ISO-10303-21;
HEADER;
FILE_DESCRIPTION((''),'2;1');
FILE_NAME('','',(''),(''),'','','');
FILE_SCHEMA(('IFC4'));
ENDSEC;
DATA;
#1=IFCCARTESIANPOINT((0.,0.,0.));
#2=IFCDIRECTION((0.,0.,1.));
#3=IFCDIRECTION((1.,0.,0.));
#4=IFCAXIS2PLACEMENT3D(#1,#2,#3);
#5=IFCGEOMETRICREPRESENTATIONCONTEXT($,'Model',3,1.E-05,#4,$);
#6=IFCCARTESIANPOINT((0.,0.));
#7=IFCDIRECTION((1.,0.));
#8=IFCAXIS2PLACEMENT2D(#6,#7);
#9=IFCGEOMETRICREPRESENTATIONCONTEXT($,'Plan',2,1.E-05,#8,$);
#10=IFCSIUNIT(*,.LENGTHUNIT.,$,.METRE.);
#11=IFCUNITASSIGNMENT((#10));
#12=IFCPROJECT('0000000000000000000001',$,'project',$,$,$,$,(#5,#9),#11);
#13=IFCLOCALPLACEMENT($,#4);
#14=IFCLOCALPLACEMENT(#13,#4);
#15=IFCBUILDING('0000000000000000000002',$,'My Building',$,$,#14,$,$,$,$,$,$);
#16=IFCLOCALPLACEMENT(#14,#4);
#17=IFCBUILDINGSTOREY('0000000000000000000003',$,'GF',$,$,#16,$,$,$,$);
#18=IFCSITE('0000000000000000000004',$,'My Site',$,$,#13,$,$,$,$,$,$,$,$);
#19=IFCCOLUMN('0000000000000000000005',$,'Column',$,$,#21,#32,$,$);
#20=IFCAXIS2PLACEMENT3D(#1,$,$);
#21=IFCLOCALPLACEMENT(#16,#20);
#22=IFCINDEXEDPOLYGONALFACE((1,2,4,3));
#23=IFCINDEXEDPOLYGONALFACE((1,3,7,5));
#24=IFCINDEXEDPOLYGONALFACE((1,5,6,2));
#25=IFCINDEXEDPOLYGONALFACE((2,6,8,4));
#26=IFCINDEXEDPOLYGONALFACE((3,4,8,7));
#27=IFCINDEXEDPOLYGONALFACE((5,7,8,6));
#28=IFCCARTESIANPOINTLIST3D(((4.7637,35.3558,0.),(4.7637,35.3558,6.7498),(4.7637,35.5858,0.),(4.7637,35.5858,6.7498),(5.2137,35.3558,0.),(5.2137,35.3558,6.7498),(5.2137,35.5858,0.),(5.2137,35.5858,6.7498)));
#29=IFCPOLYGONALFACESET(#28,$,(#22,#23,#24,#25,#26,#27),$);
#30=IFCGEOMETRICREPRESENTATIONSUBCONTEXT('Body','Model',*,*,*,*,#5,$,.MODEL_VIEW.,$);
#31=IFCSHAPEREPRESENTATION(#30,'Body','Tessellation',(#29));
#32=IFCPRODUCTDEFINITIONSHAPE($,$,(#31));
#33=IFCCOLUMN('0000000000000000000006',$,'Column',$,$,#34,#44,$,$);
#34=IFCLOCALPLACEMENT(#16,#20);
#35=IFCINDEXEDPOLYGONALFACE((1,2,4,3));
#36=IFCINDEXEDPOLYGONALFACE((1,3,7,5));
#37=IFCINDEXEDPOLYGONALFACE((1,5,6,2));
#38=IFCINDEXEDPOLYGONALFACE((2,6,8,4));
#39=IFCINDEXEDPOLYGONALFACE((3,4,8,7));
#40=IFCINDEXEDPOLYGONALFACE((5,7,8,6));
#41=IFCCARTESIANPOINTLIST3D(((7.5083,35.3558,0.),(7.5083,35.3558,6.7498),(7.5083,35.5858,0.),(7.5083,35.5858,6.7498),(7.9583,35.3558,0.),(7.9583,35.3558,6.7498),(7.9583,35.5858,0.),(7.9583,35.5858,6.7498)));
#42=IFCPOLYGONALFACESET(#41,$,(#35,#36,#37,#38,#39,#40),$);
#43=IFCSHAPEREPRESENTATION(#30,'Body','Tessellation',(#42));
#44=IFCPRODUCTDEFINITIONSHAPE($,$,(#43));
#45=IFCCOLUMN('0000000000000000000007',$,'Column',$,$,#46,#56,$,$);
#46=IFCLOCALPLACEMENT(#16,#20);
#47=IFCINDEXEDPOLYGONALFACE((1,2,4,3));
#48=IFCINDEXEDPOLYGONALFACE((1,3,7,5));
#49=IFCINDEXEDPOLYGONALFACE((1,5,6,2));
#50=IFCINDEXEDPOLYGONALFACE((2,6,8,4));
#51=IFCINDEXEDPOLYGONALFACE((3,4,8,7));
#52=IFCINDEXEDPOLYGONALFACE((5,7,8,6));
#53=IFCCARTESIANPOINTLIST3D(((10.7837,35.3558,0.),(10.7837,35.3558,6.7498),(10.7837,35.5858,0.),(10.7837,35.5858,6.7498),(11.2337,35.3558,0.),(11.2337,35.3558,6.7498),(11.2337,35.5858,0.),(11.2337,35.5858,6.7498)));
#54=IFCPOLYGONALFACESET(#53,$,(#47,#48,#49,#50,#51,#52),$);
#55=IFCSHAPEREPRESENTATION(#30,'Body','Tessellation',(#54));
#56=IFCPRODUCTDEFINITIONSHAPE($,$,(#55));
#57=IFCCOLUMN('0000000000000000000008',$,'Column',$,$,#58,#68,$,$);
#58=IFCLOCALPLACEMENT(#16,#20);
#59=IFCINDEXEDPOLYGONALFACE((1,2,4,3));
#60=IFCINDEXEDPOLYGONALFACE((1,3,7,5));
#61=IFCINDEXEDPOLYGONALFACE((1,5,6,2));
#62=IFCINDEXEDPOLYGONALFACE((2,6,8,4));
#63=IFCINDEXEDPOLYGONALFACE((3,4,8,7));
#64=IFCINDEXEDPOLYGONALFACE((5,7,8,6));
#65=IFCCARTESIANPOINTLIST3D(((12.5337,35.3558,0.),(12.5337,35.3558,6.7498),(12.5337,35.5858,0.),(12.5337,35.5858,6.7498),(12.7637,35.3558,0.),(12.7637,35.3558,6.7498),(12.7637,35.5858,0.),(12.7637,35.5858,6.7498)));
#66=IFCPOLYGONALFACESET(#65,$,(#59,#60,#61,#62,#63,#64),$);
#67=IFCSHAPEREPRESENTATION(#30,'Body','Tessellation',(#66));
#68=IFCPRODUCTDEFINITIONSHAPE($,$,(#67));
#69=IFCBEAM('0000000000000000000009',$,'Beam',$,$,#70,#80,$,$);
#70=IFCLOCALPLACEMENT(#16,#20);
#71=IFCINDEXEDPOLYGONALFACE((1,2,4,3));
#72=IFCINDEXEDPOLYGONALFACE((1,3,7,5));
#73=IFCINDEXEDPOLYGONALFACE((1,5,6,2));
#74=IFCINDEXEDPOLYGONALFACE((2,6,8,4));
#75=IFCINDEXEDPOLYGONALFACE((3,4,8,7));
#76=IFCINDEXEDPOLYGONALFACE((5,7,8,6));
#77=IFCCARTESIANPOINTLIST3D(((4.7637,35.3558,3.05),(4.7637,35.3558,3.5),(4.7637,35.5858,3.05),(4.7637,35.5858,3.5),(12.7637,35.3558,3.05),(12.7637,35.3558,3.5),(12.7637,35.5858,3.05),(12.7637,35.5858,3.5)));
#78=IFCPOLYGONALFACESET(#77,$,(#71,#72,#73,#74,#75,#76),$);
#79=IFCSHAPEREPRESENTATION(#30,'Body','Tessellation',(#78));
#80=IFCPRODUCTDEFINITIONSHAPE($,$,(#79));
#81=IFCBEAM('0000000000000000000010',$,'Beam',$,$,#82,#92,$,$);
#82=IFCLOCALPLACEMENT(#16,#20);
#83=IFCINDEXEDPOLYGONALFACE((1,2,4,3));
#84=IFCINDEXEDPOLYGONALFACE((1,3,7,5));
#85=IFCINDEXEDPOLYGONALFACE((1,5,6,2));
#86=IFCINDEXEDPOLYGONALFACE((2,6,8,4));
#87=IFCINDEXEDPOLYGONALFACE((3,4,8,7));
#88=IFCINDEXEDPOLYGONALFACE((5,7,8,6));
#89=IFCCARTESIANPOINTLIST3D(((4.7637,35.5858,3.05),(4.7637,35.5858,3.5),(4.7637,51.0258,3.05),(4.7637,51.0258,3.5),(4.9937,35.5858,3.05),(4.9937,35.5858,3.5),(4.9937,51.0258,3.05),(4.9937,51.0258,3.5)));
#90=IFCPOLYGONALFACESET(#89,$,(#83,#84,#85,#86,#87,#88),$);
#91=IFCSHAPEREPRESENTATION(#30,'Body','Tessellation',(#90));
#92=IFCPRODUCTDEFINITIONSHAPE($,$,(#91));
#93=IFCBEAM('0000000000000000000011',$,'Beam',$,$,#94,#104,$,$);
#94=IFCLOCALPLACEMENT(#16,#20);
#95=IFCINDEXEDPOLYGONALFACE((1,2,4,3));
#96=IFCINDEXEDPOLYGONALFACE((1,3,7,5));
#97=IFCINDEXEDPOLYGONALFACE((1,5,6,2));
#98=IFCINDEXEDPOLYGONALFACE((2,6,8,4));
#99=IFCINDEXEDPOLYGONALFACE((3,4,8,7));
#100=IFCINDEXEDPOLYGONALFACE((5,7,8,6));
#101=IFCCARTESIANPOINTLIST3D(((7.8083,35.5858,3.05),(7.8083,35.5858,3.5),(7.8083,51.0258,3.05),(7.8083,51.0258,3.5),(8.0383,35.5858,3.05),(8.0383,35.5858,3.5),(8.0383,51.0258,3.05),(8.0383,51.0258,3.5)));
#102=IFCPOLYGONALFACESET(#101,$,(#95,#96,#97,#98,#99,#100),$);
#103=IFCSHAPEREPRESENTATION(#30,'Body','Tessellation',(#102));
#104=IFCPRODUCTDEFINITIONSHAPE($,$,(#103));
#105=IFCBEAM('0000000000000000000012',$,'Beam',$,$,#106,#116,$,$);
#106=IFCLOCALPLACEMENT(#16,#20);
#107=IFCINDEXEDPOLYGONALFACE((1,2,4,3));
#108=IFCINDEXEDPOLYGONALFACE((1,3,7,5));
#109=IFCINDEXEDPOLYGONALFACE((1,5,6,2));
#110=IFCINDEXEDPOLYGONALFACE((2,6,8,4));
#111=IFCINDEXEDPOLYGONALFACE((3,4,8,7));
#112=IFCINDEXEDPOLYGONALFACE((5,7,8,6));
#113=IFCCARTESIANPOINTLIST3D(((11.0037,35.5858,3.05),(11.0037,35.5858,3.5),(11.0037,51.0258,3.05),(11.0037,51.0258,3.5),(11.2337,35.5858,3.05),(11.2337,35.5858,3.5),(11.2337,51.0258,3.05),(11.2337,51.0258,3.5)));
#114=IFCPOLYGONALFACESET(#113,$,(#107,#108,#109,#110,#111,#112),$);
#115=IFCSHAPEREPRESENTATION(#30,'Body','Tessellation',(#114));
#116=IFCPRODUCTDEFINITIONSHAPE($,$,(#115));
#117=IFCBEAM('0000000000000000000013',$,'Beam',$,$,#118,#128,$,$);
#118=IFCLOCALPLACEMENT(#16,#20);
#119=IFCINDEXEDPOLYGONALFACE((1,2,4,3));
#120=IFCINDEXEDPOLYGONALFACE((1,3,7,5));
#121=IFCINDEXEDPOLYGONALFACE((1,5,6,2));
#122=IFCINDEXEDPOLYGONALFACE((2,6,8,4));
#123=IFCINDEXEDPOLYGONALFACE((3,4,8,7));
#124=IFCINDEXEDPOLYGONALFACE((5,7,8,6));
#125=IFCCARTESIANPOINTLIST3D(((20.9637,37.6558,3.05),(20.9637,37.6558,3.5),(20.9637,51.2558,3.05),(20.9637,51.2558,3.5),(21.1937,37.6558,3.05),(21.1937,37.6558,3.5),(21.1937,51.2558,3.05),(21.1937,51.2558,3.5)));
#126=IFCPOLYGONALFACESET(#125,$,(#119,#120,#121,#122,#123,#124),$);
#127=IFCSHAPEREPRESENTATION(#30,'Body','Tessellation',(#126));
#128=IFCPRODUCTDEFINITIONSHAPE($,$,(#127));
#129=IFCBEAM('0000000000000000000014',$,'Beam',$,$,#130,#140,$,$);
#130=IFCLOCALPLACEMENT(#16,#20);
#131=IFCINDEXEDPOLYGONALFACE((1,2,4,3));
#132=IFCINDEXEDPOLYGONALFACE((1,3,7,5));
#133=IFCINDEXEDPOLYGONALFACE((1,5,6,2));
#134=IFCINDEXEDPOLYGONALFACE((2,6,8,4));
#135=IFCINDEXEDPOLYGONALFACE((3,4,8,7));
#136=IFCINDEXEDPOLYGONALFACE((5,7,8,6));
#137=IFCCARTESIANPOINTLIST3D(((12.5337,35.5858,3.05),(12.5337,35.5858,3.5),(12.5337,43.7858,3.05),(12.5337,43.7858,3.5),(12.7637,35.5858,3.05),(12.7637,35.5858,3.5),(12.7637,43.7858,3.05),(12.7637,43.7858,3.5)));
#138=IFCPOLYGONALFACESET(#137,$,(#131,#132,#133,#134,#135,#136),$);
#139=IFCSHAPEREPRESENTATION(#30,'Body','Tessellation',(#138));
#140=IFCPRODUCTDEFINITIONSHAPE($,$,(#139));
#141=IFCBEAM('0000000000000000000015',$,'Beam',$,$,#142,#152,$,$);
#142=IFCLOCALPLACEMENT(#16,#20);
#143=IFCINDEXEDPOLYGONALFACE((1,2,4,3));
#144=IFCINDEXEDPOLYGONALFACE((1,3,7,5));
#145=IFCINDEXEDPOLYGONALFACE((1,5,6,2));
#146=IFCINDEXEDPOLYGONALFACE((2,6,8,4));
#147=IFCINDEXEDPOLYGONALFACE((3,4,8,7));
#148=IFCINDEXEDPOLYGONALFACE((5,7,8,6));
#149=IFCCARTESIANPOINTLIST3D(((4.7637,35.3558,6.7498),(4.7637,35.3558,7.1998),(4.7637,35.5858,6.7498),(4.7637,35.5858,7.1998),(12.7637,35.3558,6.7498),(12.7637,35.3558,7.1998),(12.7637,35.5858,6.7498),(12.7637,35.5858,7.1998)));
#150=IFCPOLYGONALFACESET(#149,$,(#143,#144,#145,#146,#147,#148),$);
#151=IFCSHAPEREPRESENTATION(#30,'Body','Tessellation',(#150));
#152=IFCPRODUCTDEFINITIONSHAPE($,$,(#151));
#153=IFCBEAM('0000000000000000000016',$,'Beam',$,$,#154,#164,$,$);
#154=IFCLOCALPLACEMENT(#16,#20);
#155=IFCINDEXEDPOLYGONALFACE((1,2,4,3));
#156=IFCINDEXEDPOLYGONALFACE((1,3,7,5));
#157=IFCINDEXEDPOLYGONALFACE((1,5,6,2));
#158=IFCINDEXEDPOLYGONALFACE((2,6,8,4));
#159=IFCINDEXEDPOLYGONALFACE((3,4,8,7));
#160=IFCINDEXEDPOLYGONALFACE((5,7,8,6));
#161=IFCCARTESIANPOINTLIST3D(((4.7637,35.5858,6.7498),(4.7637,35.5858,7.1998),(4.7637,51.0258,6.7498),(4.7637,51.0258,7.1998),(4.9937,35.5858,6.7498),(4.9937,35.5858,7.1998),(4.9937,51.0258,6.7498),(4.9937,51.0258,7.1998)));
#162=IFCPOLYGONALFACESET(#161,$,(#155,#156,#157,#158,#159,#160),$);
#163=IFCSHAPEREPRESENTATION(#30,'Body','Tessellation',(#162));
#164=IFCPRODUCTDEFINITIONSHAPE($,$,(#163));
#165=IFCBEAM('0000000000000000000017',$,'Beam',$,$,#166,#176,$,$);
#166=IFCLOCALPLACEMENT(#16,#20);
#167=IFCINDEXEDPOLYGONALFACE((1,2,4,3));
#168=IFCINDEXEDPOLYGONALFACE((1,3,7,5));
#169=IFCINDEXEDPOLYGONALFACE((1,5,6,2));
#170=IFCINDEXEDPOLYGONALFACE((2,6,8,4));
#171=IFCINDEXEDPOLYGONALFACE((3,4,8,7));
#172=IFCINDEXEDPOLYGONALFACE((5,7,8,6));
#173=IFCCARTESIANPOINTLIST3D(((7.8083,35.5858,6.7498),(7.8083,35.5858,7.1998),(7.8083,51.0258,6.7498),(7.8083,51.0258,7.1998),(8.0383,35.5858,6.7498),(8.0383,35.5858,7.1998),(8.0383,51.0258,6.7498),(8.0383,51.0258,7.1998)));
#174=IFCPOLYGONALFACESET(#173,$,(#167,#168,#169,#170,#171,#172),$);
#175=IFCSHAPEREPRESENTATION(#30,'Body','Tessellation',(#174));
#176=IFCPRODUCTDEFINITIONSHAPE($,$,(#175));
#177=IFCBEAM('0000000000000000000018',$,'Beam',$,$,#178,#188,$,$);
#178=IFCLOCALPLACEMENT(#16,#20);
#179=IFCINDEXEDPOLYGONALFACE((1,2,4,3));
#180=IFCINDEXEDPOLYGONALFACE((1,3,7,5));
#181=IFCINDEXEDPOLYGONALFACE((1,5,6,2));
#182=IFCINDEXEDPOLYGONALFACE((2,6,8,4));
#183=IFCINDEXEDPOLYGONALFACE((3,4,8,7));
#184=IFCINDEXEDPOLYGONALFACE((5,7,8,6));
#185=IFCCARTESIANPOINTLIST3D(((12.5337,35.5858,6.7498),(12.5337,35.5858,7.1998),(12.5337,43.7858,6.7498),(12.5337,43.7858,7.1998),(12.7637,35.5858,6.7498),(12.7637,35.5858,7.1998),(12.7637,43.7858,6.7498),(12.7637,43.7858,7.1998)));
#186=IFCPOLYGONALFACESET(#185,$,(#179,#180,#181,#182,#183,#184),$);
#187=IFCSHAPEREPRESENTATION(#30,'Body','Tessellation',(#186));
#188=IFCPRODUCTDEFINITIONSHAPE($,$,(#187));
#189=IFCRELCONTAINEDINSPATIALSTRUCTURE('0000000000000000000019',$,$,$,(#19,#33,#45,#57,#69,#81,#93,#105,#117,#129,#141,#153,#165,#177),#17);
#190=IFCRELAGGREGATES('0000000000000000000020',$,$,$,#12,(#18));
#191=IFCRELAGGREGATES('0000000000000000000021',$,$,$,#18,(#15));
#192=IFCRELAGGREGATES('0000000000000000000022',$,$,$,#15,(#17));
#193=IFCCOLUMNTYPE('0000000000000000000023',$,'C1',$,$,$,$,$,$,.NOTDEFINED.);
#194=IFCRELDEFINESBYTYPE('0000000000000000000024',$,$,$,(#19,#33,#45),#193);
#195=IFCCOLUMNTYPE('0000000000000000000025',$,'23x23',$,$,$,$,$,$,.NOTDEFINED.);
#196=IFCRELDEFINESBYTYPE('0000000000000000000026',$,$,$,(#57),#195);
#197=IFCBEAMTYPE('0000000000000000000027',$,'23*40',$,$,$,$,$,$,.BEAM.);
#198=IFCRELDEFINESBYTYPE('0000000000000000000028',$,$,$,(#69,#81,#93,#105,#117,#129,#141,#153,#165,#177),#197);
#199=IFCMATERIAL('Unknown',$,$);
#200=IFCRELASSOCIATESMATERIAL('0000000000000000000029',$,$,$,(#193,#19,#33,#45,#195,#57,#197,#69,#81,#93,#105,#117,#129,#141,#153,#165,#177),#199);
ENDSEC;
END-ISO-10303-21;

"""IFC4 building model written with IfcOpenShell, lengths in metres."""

from ifc_helpers import new_model, si_unit, frame, origin_with_axes, origin_2d_with_axis, place, context, subcontext, project, spatial, rectangle, extrude, material, material_profile, profile_set, profile_usage, type_object, element, save


model = new_model("IFC4")

# Units and contexts
model_context = context("Model", 3, precision=1e-05, world=origin_with_axes())
plan_context = context("Plan", 2, precision=1e-05, world=origin_2d_with_axis())
body_context = subcontext(model_context, "Body", "Model", "MODEL_VIEW")
ifc_project = project(units=[si_unit("LENGTHUNIT", "METRE")], contexts=[model_context, plan_context])

# Site, building, storey
site_placement = place(None, origin_with_axes())
site = spatial("IfcSite", under=ifc_project, at=site_placement, Name="My Site")
building_placement = place(site_placement, origin_with_axes())
building = spatial("IfcBuilding", under=site, at=building_placement, Name="My Building")
storey_placement = place(building_placement, origin_with_axes())
storey = spatial("IfcBuildingStorey", under=building, at=storey_placement, Name="GF")

# Columns
ifc_material = material(Name="Unknown")
ifc_material_profile_1 = material_profile(ifc_material, rectangle(XDim=0.45, YDim=0.23))
ifc_profile_set_1 = profile_set([ifc_material_profile_1])
ifc_profile_usage_1 = profile_usage(ifc_profile_set_1, cardinal=5)
column_type_1 = type_object("IfcColumnType", Name="C1", PredefinedType="NOTDEFINED", material=ifc_profile_set_1)
column_1_placement = place(storey_placement, frame((4.9887, 35.4708, 0.0), z_axis=(0.0, 0.0, 1.0), x_axis=(1.0, 0.0, 0.0)))
element("IfcColumn", 1, at=column_1_placement, inside=storey, type_object=column_type_1, material=ifc_profile_usage_1, Name="Column", context=body_context, shape_type="SweptSolid", body=[
    extrude(rectangle(XDim=0.45, YDim=0.23), origin_with_axes(), (0.0, 0.0, 1.0), 6.7498),
])
ifc_profile_usage_2 = profile_usage(ifc_profile_set_1, cardinal=5)
column_2_placement = place(storey_placement, frame((7.7333, 35.4708, 0.0), z_axis=(0.0, 0.0, 1.0), x_axis=(-1.0, 0.0, 0.0)))
element("IfcColumn", 2, at=column_2_placement, inside=storey, type_object=column_type_1, material=ifc_profile_usage_2, Name="Column", context=body_context, shape_type="SweptSolid", body=[
    extrude(rectangle(XDim=0.45, YDim=0.23), origin_with_axes(), (0.0, 0.0, 1.0), 6.7498),
])
ifc_profile_usage_3 = profile_usage(ifc_profile_set_1, cardinal=5)
column_3_placement = place(storey_placement, frame((11.0087, 35.4708, 0.0), z_axis=(0.0, 0.0, 1.0), x_axis=(-1.0, 0.0, 0.0)))
element("IfcColumn", 3, at=column_3_placement, inside=storey, type_object=column_type_1, material=ifc_profile_usage_3, Name="Column", context=body_context, shape_type="SweptSolid", body=[
    extrude(rectangle(XDim=0.45, YDim=0.23), origin_with_axes(), (0.0, 0.0, 1.0), 6.7498),
])
ifc_material_profile_2 = material_profile(ifc_material, rectangle(XDim=0.23, YDim=0.23))
ifc_profile_set_2 = profile_set([ifc_material_profile_2])
ifc_profile_usage_4 = profile_usage(ifc_profile_set_2, cardinal=5)
column_type_2 = type_object("IfcColumnType", Name="23x23", PredefinedType="NOTDEFINED", material=ifc_profile_set_2)
column_4_placement = place(storey_placement, frame((12.6487, 35.4708, 0.0), z_axis=(0.0, 0.0, 1.0), x_axis=(1.0, 0.0, 0.0)))
element("IfcColumn", 4, at=column_4_placement, inside=storey, type_object=column_type_2, material=ifc_profile_usage_4, Name="Column", context=body_context, shape_type="SweptSolid", body=[
    extrude(rectangle(XDim=0.23, YDim=0.23), origin_with_axes(), (0.0, 0.0, 1.0), 6.7498),
])

# Beams
ifc_material_profile_3 = material_profile(ifc_material, rectangle(XDim=0.23, YDim=0.45))
ifc_profile_set_3 = profile_set([ifc_material_profile_3])
ifc_profile_usage_5 = profile_usage(ifc_profile_set_3, cardinal=5)
beam_type = type_object("IfcBeamType", Name="23*40", PredefinedType="BEAM", material=ifc_profile_set_3)
beam_1_placement = place(storey_placement, frame((4.7637, 35.4708, 3.275), z_axis=(1.0, 0.0, 0.0), x_axis=(0.0, 1.0, 0.0)))
element("IfcBeam", 5, at=beam_1_placement, inside=storey, type_object=beam_type, material=ifc_profile_usage_5, Name="Beam", context=body_context, shape_type="SweptSolid", body=[
    extrude(rectangle(XDim=0.23, YDim=0.45), origin_with_axes(), (0.0, 0.0, 1.0), 8.0),
])
ifc_profile_usage_6 = profile_usage(ifc_profile_set_3, cardinal=5)
beam_2_placement = place(storey_placement, frame((4.8787, 35.5858, 3.275), z_axis=(0.0, 1.0, 0.0), x_axis=(-1.0, 0.0, 0.0)))
element("IfcBeam", 6, at=beam_2_placement, inside=storey, type_object=beam_type, material=ifc_profile_usage_6, Name="Beam", context=body_context, shape_type="SweptSolid", body=[
    extrude(rectangle(XDim=0.23, YDim=0.45), origin_with_axes(), (0.0, 0.0, 1.0), 15.44),
])
ifc_profile_usage_7 = profile_usage(ifc_profile_set_3, cardinal=5)
beam_3_placement = place(storey_placement, frame((7.9233, 35.5858, 3.275), z_axis=(0.0, 1.0, 0.0), x_axis=(-1.0, 0.0, 0.0)))
element("IfcBeam", 7, at=beam_3_placement, inside=storey, type_object=beam_type, material=ifc_profile_usage_7, Name="Beam", context=body_context, shape_type="SweptSolid", body=[
    extrude(rectangle(XDim=0.23, YDim=0.45), origin_with_axes(), (0.0, 0.0, 1.0), 15.44),
])
ifc_profile_usage_8 = profile_usage(ifc_profile_set_3, cardinal=5)
beam_4_placement = place(storey_placement, frame((11.1187, 35.5858, 3.275), z_axis=(0.0, 1.0, 0.0), x_axis=(-1.0, 0.0, 0.0)))
element("IfcBeam", 8, at=beam_4_placement, inside=storey, type_object=beam_type, material=ifc_profile_usage_8, Name="Beam", context=body_context, shape_type="SweptSolid", body=[
    extrude(rectangle(XDim=0.23, YDim=0.45), origin_with_axes(), (0.0, 0.0, 1.0), 15.44),
])
ifc_profile_usage_9 = profile_usage(ifc_profile_set_3, cardinal=5)
beam_5_placement = place(storey_placement, frame((21.0787, 37.6558, 3.275), z_axis=(0.0, 1.0, 0.0), x_axis=(-1.0, 0.0, 0.0)))
element("IfcBeam", 9, at=beam_5_placement, inside=storey, type_object=beam_type, material=ifc_profile_usage_9, Name="Beam", context=body_context, shape_type="SweptSolid", body=[
    extrude(rectangle(XDim=0.23, YDim=0.45), origin_with_axes(), (0.0, 0.0, 1.0), 13.6),
])
ifc_profile_usage_10 = profile_usage(ifc_profile_set_3, cardinal=5)
beam_6_placement = place(storey_placement, frame((12.6487, 35.5858, 3.275), z_axis=(0.0, 1.0, 0.0), x_axis=(-1.0, 0.0, 0.0)))
element("IfcBeam", 10, at=beam_6_placement, inside=storey, type_object=beam_type, material=ifc_profile_usage_10, Name="Beam", context=body_context, shape_type="SweptSolid", body=[
    extrude(rectangle(XDim=0.23, YDim=0.45), origin_with_axes(), (0.0, 0.0, 1.0), 8.2),
])
ifc_profile_usage_11 = profile_usage(ifc_profile_set_3, cardinal=5)
beam_7_placement = place(storey_placement, frame((4.7637, 35.4708, 6.9748), z_axis=(1.0, 0.0, 0.0), x_axis=(0.0, 1.0, 0.0)))
element("IfcBeam", 11, at=beam_7_placement, inside=storey, type_object=beam_type, material=ifc_profile_usage_11, Name="Beam", context=body_context, shape_type="SweptSolid", body=[
    extrude(rectangle(XDim=0.23, YDim=0.45), origin_with_axes(), (0.0, 0.0, 1.0), 8.0),
])
ifc_profile_usage_12 = profile_usage(ifc_profile_set_3, cardinal=5)
beam_8_placement = place(storey_placement, frame((4.8787, 35.5858, 6.9748), z_axis=(0.0, 1.0, 0.0), x_axis=(-1.0, 0.0, 0.0)))
element("IfcBeam", 12, at=beam_8_placement, inside=storey, type_object=beam_type, material=ifc_profile_usage_12, Name="Beam", context=body_context, shape_type="SweptSolid", body=[
    extrude(rectangle(XDim=0.23, YDim=0.45), origin_with_axes(), (0.0, 0.0, 1.0), 15.44),
])
ifc_profile_usage_13 = profile_usage(ifc_profile_set_3, cardinal=5)
beam_9_placement = place(storey_placement, frame((7.9233, 35.5858, 6.9748), z_axis=(0.0, 1.0, 0.0), x_axis=(-1.0, 0.0, 0.0)))
element("IfcBeam", 13, at=beam_9_placement, inside=storey, type_object=beam_type, material=ifc_profile_usage_13, Name="Beam", context=body_context, shape_type="SweptSolid", body=[
    extrude(rectangle(XDim=0.23, YDim=0.45), origin_with_axes(), (0.0, 0.0, 1.0), 15.44),
])
ifc_profile_usage_14 = profile_usage(ifc_profile_set_3, cardinal=5)
beam_10_placement = place(storey_placement, frame((12.6487, 35.5858, 6.9748), z_axis=(0.0, 1.0, 0.0), x_axis=(-1.0, 0.0, 0.0)))
element("IfcBeam", 14, at=beam_10_placement, inside=storey, type_object=beam_type, material=ifc_profile_usage_14, Name="Beam", context=body_context, shape_type="SweptSolid", body=[
    extrude(rectangle(XDim=0.23, YDim=0.45), origin_with_axes(), (0.0, 0.0, 1.0), 8.2),
])

save(model, "model.ifc")
